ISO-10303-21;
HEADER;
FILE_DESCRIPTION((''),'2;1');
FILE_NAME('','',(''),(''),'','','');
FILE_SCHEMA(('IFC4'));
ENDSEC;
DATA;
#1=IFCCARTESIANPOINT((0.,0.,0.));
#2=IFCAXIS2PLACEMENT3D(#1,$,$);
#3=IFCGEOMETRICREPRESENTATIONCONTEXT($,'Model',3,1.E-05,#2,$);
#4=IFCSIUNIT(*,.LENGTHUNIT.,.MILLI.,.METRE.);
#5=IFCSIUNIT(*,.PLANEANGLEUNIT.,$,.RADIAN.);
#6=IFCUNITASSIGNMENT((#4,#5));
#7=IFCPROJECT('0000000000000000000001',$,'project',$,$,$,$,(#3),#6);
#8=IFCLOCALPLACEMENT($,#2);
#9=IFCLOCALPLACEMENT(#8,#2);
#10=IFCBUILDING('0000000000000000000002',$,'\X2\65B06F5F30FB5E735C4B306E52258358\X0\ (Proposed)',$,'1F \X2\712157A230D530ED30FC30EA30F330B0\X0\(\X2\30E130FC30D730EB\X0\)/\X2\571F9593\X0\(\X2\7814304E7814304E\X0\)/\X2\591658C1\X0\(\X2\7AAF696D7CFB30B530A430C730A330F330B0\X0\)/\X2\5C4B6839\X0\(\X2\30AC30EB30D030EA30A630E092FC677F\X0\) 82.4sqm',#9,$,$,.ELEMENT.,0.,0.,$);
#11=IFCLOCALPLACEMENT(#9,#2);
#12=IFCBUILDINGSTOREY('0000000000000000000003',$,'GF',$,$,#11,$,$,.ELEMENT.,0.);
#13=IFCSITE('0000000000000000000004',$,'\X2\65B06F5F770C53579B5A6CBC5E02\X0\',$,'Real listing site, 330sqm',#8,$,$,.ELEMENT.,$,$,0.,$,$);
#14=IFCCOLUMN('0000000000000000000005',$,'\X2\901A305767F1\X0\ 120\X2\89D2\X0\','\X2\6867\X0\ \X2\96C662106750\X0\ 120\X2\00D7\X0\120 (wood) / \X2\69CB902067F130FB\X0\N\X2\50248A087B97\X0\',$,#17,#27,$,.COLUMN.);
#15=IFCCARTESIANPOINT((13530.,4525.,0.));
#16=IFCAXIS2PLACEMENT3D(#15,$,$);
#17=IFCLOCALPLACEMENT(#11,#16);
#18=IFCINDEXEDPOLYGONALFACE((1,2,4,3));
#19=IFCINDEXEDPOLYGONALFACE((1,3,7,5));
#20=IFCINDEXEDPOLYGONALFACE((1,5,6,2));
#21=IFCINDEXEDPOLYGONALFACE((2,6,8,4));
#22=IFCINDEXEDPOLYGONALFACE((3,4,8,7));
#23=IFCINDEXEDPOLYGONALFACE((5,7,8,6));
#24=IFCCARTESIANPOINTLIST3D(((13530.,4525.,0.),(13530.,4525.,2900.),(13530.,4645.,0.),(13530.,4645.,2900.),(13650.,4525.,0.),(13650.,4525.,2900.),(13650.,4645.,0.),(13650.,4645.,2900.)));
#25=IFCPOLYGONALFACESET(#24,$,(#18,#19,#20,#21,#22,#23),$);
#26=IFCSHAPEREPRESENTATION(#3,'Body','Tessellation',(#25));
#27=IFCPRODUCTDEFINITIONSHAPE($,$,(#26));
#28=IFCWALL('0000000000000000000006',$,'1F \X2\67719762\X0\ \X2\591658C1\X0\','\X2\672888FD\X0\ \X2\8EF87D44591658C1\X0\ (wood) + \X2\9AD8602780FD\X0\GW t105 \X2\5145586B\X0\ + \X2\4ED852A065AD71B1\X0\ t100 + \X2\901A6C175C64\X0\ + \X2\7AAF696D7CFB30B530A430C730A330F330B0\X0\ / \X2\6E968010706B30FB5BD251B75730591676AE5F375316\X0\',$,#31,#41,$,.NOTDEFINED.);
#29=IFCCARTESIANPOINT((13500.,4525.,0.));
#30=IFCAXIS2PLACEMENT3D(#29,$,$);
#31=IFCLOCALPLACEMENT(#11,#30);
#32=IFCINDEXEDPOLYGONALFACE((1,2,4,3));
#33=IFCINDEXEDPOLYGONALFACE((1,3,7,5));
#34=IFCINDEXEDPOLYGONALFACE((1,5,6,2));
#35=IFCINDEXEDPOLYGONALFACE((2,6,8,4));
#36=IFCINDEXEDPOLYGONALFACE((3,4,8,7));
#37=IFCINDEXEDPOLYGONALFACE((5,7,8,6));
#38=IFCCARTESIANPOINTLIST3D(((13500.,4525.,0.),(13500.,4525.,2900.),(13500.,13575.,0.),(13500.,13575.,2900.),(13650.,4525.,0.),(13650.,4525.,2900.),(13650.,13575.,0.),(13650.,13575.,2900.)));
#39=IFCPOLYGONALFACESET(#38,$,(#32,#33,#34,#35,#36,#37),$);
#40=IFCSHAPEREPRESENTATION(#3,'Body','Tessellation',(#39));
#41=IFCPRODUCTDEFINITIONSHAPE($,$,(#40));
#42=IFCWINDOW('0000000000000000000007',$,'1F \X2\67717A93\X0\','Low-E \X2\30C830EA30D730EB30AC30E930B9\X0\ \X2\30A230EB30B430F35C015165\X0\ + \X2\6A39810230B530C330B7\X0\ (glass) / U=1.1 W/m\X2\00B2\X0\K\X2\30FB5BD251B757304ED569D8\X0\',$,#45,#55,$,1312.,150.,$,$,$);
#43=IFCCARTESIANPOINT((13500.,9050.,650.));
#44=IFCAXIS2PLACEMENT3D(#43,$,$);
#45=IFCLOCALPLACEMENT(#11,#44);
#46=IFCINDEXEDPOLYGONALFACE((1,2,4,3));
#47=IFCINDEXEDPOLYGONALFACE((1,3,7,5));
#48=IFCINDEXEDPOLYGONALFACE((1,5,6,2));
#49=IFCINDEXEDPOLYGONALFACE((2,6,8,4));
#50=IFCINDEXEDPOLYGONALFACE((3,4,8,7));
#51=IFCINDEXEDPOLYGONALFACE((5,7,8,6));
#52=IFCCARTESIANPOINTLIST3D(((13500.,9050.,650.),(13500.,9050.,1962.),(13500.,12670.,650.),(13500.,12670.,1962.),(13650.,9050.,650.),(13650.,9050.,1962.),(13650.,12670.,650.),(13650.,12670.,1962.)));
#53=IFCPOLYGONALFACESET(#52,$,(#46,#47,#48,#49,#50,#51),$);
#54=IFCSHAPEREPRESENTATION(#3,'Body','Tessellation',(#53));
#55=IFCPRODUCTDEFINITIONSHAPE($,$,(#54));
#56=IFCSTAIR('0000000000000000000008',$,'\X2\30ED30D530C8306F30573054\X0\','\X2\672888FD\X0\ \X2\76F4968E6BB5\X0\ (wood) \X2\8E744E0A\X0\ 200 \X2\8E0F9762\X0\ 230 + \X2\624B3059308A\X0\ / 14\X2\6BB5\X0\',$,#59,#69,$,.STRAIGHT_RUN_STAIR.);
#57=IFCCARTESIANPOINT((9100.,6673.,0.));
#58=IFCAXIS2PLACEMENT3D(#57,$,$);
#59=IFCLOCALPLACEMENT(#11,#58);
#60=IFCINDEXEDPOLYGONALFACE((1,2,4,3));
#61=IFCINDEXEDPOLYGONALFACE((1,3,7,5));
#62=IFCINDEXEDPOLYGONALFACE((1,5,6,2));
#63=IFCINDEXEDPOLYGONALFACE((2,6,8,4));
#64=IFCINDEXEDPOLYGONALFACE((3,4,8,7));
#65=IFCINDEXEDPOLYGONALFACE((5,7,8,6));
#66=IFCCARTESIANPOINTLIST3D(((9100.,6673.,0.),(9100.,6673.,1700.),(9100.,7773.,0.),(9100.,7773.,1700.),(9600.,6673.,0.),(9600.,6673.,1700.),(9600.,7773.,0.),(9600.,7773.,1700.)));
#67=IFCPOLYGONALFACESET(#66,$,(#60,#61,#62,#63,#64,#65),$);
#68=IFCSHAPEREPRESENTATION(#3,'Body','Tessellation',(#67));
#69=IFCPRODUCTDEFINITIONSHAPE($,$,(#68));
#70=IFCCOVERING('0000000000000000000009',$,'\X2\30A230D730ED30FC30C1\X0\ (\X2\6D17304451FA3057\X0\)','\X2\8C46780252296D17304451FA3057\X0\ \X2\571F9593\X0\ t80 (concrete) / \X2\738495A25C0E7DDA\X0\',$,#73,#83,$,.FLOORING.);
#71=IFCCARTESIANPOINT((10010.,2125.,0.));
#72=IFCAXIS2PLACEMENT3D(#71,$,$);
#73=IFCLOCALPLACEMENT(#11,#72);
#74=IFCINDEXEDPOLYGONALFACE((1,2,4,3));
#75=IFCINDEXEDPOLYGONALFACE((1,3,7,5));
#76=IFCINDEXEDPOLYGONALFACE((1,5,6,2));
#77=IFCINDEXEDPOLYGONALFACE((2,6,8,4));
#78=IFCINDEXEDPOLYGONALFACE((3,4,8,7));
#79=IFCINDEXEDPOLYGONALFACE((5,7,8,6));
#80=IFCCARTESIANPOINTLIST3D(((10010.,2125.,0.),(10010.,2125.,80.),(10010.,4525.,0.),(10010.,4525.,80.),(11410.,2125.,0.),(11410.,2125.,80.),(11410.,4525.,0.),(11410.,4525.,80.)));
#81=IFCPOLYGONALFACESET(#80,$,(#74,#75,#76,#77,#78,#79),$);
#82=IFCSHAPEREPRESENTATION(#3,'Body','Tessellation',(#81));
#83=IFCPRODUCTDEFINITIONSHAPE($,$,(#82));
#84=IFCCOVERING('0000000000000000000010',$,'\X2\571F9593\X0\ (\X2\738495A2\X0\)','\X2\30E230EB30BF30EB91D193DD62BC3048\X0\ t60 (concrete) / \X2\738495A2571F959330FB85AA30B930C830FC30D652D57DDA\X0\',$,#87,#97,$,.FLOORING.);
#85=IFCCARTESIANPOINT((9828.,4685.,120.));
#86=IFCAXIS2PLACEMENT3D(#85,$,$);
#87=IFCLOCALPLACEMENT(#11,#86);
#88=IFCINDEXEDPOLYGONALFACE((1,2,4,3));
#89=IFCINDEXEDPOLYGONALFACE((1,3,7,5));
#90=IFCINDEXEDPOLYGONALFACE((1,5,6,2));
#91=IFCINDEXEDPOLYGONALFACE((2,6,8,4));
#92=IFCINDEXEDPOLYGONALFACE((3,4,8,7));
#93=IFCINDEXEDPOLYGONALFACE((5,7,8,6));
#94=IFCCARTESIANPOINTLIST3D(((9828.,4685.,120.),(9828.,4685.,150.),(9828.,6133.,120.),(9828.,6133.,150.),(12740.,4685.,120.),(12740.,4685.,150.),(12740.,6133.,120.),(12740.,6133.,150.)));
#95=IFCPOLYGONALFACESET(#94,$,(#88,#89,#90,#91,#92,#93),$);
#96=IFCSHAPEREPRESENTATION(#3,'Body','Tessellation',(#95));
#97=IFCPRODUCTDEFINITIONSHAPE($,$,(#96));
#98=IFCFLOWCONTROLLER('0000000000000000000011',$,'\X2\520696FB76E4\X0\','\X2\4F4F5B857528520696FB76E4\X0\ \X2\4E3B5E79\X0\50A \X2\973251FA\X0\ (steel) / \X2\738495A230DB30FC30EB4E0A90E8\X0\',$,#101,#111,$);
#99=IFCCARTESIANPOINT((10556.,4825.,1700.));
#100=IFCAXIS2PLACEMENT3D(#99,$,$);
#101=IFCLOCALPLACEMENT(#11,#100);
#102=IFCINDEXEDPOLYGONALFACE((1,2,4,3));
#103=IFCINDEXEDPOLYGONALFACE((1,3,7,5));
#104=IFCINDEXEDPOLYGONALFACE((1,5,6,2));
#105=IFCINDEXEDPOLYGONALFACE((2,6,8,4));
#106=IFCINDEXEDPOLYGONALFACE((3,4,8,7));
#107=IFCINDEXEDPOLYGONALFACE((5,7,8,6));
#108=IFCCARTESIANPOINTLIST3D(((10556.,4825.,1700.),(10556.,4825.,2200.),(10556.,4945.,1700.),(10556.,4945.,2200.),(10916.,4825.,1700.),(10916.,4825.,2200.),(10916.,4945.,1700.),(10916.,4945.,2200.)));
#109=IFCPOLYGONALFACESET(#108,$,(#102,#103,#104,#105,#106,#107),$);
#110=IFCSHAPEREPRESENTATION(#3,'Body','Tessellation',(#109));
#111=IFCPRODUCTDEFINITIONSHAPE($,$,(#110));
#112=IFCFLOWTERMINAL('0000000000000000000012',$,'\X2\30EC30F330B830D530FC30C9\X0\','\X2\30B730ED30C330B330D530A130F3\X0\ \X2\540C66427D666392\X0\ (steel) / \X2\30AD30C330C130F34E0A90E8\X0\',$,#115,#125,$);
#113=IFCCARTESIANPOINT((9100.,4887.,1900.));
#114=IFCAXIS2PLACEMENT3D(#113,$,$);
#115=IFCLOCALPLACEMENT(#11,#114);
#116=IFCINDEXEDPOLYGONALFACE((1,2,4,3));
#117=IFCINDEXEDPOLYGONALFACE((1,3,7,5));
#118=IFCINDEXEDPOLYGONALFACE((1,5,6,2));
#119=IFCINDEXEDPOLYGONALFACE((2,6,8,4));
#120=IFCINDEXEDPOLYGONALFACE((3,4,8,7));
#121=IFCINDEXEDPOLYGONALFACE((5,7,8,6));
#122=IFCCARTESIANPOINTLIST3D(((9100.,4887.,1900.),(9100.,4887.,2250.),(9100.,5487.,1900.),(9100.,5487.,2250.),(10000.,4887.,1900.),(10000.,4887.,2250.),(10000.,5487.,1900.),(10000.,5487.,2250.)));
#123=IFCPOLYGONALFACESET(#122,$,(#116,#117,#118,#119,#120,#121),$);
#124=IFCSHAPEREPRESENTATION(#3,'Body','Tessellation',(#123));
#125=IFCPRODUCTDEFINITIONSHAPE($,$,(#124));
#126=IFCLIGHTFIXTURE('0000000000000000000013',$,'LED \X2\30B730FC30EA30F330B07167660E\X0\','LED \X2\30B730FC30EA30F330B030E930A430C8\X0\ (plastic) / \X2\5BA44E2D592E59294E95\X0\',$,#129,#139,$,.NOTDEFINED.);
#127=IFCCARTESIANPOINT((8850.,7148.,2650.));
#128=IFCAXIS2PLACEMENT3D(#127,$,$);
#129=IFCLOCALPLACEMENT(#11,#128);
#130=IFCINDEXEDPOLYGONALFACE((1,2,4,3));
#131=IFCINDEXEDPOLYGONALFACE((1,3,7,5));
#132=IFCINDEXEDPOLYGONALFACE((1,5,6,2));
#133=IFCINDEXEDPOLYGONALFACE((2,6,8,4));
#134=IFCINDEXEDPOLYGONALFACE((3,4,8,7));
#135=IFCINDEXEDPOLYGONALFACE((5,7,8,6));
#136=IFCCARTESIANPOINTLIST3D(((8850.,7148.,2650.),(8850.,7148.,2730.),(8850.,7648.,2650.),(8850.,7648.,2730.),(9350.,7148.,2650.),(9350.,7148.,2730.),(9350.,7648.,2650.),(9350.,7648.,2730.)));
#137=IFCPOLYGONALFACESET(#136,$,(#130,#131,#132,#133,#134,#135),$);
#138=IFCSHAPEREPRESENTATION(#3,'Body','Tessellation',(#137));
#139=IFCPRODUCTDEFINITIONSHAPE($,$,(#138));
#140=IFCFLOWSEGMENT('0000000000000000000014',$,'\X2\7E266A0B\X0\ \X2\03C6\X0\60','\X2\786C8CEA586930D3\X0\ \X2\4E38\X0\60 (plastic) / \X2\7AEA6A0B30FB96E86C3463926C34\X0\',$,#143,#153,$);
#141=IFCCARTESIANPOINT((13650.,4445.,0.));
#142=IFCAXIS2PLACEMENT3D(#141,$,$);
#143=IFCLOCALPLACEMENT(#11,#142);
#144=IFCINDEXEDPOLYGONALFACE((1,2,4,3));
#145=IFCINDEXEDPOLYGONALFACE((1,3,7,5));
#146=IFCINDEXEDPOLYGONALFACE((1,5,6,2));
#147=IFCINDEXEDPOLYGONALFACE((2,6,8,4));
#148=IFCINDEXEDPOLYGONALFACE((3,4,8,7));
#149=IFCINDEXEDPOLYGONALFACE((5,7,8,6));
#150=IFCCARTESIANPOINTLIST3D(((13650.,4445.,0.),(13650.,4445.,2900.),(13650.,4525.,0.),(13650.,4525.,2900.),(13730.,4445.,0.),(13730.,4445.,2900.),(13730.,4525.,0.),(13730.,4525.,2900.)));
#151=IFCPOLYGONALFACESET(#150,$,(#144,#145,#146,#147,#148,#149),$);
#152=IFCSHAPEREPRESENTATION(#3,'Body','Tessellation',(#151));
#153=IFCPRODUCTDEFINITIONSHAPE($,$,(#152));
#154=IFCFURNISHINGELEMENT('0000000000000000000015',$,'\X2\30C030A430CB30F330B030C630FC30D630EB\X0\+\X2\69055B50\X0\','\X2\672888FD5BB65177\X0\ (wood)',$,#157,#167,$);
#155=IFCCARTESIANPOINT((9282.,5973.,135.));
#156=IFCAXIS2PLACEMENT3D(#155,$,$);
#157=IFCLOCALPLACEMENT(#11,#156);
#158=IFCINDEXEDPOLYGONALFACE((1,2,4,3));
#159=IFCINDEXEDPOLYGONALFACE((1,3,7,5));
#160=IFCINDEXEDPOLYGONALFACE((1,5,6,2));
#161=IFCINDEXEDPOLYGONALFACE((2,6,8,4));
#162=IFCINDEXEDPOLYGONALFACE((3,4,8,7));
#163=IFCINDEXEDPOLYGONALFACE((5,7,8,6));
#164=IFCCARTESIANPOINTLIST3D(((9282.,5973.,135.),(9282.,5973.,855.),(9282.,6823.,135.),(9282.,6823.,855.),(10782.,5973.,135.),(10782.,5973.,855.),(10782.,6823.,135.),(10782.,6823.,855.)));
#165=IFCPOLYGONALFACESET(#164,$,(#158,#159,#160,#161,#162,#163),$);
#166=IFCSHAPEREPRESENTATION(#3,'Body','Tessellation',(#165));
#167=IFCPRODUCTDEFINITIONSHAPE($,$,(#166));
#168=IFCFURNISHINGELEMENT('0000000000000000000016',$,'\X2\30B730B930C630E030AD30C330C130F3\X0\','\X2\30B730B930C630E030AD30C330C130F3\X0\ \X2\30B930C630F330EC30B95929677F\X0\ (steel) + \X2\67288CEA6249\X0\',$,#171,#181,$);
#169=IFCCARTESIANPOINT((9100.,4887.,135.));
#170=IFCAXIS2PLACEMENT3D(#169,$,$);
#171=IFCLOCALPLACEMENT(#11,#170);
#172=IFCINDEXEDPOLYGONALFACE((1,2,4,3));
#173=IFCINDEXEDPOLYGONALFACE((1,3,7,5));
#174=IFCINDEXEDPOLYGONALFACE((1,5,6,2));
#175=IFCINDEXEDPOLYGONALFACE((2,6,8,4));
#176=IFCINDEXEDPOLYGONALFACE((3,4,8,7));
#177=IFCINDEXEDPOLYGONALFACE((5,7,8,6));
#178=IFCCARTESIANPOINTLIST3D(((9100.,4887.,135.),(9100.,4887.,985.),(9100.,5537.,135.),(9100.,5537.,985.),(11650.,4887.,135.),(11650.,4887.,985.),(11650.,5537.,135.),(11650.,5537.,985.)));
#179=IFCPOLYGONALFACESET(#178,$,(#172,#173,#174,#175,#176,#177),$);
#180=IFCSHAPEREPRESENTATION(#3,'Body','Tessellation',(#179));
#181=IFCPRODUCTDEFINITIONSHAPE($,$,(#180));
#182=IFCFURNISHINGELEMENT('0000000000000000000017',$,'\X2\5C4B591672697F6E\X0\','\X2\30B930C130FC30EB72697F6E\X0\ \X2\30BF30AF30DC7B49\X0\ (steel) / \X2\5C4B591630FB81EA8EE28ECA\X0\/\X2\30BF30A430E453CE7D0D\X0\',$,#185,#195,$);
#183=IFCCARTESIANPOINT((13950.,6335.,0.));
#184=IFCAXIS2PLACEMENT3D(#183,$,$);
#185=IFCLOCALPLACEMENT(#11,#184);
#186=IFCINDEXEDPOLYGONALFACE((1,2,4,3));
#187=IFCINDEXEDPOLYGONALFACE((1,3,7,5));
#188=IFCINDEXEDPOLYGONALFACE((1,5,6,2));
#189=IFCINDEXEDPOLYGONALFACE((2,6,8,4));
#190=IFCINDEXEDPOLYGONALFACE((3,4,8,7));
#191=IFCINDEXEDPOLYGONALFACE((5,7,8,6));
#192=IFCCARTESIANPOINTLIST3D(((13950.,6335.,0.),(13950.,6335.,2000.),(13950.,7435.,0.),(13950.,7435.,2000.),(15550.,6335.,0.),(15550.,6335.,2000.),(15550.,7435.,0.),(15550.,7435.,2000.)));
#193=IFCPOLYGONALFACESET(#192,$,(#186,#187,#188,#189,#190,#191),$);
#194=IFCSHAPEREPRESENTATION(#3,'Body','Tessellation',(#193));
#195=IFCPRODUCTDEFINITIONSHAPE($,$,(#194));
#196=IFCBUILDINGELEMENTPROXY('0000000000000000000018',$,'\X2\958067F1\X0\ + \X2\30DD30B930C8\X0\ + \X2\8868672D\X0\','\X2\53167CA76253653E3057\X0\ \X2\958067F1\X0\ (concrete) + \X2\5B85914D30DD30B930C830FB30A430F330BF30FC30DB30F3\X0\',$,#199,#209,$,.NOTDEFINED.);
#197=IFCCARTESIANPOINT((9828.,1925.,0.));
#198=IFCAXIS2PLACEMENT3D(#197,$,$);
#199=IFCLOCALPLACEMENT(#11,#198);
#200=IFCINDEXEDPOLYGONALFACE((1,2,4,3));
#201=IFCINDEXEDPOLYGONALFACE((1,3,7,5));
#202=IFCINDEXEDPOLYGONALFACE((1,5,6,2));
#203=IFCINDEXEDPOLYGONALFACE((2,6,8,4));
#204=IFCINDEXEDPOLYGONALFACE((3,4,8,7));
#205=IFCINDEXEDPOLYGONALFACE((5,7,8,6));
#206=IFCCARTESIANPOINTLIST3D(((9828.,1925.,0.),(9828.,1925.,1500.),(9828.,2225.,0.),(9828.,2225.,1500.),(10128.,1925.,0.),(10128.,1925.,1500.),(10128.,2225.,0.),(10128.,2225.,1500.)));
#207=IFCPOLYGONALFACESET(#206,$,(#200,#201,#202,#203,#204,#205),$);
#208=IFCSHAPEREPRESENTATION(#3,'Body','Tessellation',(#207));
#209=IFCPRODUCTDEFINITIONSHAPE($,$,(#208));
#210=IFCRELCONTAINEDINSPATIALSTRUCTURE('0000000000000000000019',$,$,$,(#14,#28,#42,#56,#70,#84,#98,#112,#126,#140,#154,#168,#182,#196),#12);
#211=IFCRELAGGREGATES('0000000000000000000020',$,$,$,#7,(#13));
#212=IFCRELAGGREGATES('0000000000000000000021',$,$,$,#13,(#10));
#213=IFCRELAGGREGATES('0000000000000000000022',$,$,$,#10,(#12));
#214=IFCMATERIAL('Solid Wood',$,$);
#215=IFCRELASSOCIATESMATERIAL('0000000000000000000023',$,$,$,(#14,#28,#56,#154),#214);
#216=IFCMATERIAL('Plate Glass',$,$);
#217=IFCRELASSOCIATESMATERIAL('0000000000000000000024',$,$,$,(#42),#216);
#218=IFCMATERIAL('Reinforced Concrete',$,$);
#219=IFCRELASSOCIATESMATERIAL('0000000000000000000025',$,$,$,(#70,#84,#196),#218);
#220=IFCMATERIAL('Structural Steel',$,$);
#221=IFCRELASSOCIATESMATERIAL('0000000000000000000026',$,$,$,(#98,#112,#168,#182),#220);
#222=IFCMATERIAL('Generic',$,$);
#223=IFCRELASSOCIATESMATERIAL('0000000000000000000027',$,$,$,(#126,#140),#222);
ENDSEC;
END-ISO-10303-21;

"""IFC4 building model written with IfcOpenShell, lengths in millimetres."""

from ifc_helpers import new_model, si_unit, frame, frame_2d, origin, place, context, project, spatial, rectangle, extrude, material, element, fill, save


model = new_model("IFC4")

# Units and contexts
model_context = context("Model", 3, precision=1e-05, world=origin())
ifc_project = project(units=[si_unit("LENGTHUNIT", "METRE", prefix="MILLI"), si_unit("PLANEANGLEUNIT", "RADIAN")], contexts=[model_context])

# Site, building, storey
site_placement = place(None, origin())
site = spatial("IfcSite", under=ifc_project, at=site_placement, Name="新潟県南魚沼市", ObjectType="Real listing site, 330sqm", CompositionType="ELEMENT", RefElevation=0.0)
building_placement = place(site_placement, origin())
building = spatial("IfcBuilding", under=site, at=building_placement, Name="新潟・平屋の別荘 (Proposed)", ObjectType="1F 無垢フローリング(メープル)/土間(研ぎ研ぎ)/外壁(窯業系サイディング)/屋根(ガルバリウム鋼板) 82.4sqm", CompositionType="ELEMENT", ElevationOfRefHeight=0.0, ElevationOfTerrain=0.0)
storey_placement = place(building_placement, origin())
storey = spatial("IfcBuildingStorey", under=building, at=storey_placement, Name="GF", CompositionType="ELEMENT", Elevation=0.0)

# Column
ifc_material_1 = material(Name="Solid Wood")
column_1_placement = place(storey_placement, frame((13530.0, 4525.0, 0.0)))
element("IfcColumn", 1, at=column_1_placement, inside=storey, material=ifc_material_1, Name="通し柱 120角", Description="桧 集成材 120×120 (wood) / 構造柱・N値計算", PredefinedType="COLUMN", context=model_context, shape_type="SweptSolid", body=[
    extrude(rectangle(XDim=120.0, YDim=120.0, at=frame_2d((60.0, 60.0))), frame((13530.0, 4525.0, 0.0)), (0.0, 0.0, 1.0), 2900.0),
])

# Wall, opening, window
wall_1_placement = place(storey_placement, frame((13500.0, 4525.0, 0.0)))
wall_1 = element("IfcWall", 2, at=wall_1_placement, inside=storey, material=ifc_material_1, Name="1F 東面 外壁", Description="木製 軸組外壁 (wood) + 高性能GW t105 充填 + 付加断熱 t100 + 通気層 + 窯業系サイディング / 準耐火・寒冷地外皮強化", PredefinedType="NOTDEFINED", context=model_context, shape_type="SweptSolid", body=[
    extrude(rectangle(XDim=150.0, YDim=9050.0, at=frame_2d((75.0, 4525.0))), frame((13500.0, 4525.0, 0.0)), (0.0, 0.0, 1.0), 2900.0),
])
opening_placement = place(storey_placement, frame((13500.0, 9050.0, 650.0)))
opening = element("IfcOpeningElement", 3, at=opening_placement, cuts=wall_1, PredefinedType="NOTDEFINED", context=model_context, shape_type="SweptSolid", body=[
    extrude(rectangle(XDim=150.0, YDim=3620.0, at=frame_2d((75.0, 1810.0))), frame((13500.0, 9050.0, 650.0)), (0.0, 0.0, 1.0), 1312.0),
])
ifc_material_2 = material(Name="Plate Glass")
window_placement = place(storey_placement, frame((13500.0, 9050.0, 650.0)))
window = element("IfcWindow", 4, at=window_placement, inside=storey, material=ifc_material_2, Name="1F 東窓", Description="Low-E トリプルガラス アルゴン封入 + 樹脂サッシ (glass) / U=1.1 W/m²K・寒冷地仕様", OverallHeight=1312.0, OverallWidth=150.0, context=model_context, shape_type="SweptSolid", body=[
    extrude(rectangle(XDim=150.0, YDim=3620.0, at=frame_2d((75.0, 1810.0))), frame((13500.0, 9050.0, 650.0)), (0.0, 0.0, 1.0), 1312.0),
])
fill(opening, window)

# Stair
stair_placement = place(storey_placement, frame((9100.0, 6673.0, 0.0)))
element("IfcStair", 5, at=stair_placement, inside=storey, material=ifc_material_1, Name="ロフトはしご", Description="木製 直階段 (wood) 蹴上 200 踏面 230 + 手すり / 14段", PredefinedType="STRAIGHT_RUN_STAIR", context=model_context, shape_type="SweptSolid", body=[
    extrude(rectangle(XDim=500.0, YDim=1100.0, at=frame_2d((250.0, 550.0))), frame((9100.0, 6673.0, 0.0)), (0.0, 0.0, 1.0), 1700.0),
])

# Coverings
ifc_material_3 = material(Name="Reinforced Concrete")
covering_1_placement = place(storey_placement, frame((10010.0, 2125.0, 0.0)))
element("IfcCovering", 6, at=covering_1_placement, inside=storey, material=ifc_material_3, Name="アプローチ (洗い出し)", Description="豆砂利洗い出し 土間 t80 (concrete) / 玄関導線", PredefinedType="FLOORING", context=model_context, shape_type="SweptSolid", body=[
    extrude(rectangle(XDim=1400.0, YDim=2400.0, at=frame_2d((700.0, 1200.0))), frame((10010.0, 2125.0, 0.0)), (0.0, 0.0, 1.0), 80.0),
])
covering_2_placement = place(storey_placement, frame((9828.0, 4685.0, 120.0)))
element("IfcCovering", 7, at=covering_2_placement, inside=storey, material=ifc_material_3, Name="土間 (玄関)", Description="モルタル金鏝押え t60 (concrete) / 玄関土間・薪ストーブ動線", PredefinedType="FLOORING", context=model_context, shape_type="SweptSolid", body=[
    extrude(rectangle(XDim=2912.0, YDim=1448.0, at=frame_2d((1456.0, 724.0))), frame((9828.0, 4685.0, 120.0)), (0.0, 0.0, 1.0), 30.0),
])

# Flow controller
ifc_material_4 = material(Name="Structural Steel")
flow_controller_placement = place(storey_placement, frame((10556.0, 4825.0, 1700.0)))
element("IfcFlowController", 8, at=flow_controller_placement, inside=storey, material=ifc_material_4, Name="分電盤", Description="住宅用分電盤 主幹50A 露出 (steel) / 玄関ホール上部", context=model_context, shape_type="SweptSolid", body=[
    extrude(rectangle(XDim=360.0, YDim=120.0, at=frame_2d((180.0, 60.0))), frame((10556.0, 4825.0, 1700.0)), (0.0, 0.0, 1.0), 500.0),
])

# Flow terminal
flow_terminal_placement = place(storey_placement, frame((9100.0, 4887.0, 1900.0)))
element("IfcFlowTerminal", 9, at=flow_terminal_placement, inside=storey, material=ifc_material_4, Name="レンジフード", Description="シロッコファン 同時給排 (steel) / キッチン上部", context=model_context, shape_type="SweptSolid", body=[
    extrude(rectangle(XDim=900.0, YDim=600.0, at=frame_2d((450.0, 300.0))), frame((9100.0, 4887.0, 1900.0)), (0.0, 0.0, 1.0), 350.0),
])

# Light fixture
ifc_material_5 = material(Name="Generic")
light_fixture_placement = place(storey_placement, frame((8850.0, 7148.0, 2650.0)))
element("IfcLightFixture", 10, at=light_fixture_placement, inside=storey, material=ifc_material_5, Name="LED シーリング照明", Description="LED シーリングライト (plastic) / 室中央天井", PredefinedType="NOTDEFINED", context=model_context, shape_type="SweptSolid", body=[
    extrude(rectangle(XDim=500.0, YDim=500.0, at=frame_2d((250.0, 250.0))), frame((8850.0, 7148.0, 2650.0)), (0.0, 0.0, 1.0), 80.0),
])

# Flow segment
flow_segment_placement = place(storey_placement, frame((13650.0, 4445.0, 0.0)))
element("IfcFlowSegment", 11, at=flow_segment_placement, inside=storey, material=ifc_material_5, Name="縦樋 φ60", Description="硬質塩ビ 丸60 (plastic) / 竪樋・雨水排水", context=model_context, shape_type="SweptSolid", body=[
    extrude(rectangle(XDim=80.0, YDim=80.0, at=frame_2d((40.0, 40.0))), frame((13650.0, 4445.0, 0.0)), (0.0, 0.0, 1.0), 2900.0),
])

# Furnishing elements
furnishing_1_placement = place(storey_placement, frame((9282.0, 5973.0, 135.0)))
element("IfcFurnishingElement", 12, at=furnishing_1_placement, inside=storey, material=ifc_material_1, Name="ダイニングテーブル+椅子", Description="木製家具 (wood)", context=model_context, shape_type="SweptSolid", body=[
    extrude(rectangle(XDim=1500.0, YDim=850.0, at=frame_2d((750.0, 425.0))), frame((9282.0, 5973.0, 135.0)), (0.0, 0.0, 1.0), 720.0),
])
furnishing_2_placement = place(storey_placement, frame((9100.0, 4887.0, 135.0)))
element("IfcFurnishingElement", 13, at=furnishing_2_placement, inside=storey, material=ifc_material_4, Name="システムキッチン", Description="システムキッチン ステンレス天板 (steel) + 木質扉", context=model_context, shape_type="SweptSolid", body=[
    extrude(rectangle(XDim=2550.0, YDim=650.0, at=frame_2d((1275.0, 325.0))), frame((9100.0, 4887.0, 135.0)), (0.0, 0.0, 1.0), 850.0),
])
furnishing_3_placement = place(storey_placement, frame((13950.0, 6335.0, 0.0)))
element("IfcFurnishingElement", 14, at=furnishing_3_placement, inside=storey, material=ifc_material_4, Name="屋外物置", Description="スチール物置 タクボ等 (steel) / 屋外・自転車/タイヤ収納", context=model_context, shape_type="SweptSolid", body=[
    extrude(rectangle(XDim=1600.0, YDim=1100.0, at=frame_2d((800.0, 550.0))), frame((13950.0, 6335.0, 0.0)), (0.0, 0.0, 1.0), 2000.0),
])

# Building element proxy
proxy_placement = place(storey_placement, frame((9828.0, 1925.0, 0.0)))
element("IfcBuildingElementProxy", 15, at=proxy_placement, inside=storey, material=ifc_material_3, Name="門柱 + ポスト + 表札", Description="化粧打放し 門柱 (concrete) + 宅配ポスト・インターホン", PredefinedType="NOTDEFINED", context=model_context, shape_type="SweptSolid", body=[
    extrude(rectangle(XDim=300.0, YDim=300.0, at=frame_2d((150.0, 150.0))), frame((9828.0, 1925.0, 0.0)), (0.0, 0.0, 1.0), 1500.0),
])

save(model, "model.ifc")
